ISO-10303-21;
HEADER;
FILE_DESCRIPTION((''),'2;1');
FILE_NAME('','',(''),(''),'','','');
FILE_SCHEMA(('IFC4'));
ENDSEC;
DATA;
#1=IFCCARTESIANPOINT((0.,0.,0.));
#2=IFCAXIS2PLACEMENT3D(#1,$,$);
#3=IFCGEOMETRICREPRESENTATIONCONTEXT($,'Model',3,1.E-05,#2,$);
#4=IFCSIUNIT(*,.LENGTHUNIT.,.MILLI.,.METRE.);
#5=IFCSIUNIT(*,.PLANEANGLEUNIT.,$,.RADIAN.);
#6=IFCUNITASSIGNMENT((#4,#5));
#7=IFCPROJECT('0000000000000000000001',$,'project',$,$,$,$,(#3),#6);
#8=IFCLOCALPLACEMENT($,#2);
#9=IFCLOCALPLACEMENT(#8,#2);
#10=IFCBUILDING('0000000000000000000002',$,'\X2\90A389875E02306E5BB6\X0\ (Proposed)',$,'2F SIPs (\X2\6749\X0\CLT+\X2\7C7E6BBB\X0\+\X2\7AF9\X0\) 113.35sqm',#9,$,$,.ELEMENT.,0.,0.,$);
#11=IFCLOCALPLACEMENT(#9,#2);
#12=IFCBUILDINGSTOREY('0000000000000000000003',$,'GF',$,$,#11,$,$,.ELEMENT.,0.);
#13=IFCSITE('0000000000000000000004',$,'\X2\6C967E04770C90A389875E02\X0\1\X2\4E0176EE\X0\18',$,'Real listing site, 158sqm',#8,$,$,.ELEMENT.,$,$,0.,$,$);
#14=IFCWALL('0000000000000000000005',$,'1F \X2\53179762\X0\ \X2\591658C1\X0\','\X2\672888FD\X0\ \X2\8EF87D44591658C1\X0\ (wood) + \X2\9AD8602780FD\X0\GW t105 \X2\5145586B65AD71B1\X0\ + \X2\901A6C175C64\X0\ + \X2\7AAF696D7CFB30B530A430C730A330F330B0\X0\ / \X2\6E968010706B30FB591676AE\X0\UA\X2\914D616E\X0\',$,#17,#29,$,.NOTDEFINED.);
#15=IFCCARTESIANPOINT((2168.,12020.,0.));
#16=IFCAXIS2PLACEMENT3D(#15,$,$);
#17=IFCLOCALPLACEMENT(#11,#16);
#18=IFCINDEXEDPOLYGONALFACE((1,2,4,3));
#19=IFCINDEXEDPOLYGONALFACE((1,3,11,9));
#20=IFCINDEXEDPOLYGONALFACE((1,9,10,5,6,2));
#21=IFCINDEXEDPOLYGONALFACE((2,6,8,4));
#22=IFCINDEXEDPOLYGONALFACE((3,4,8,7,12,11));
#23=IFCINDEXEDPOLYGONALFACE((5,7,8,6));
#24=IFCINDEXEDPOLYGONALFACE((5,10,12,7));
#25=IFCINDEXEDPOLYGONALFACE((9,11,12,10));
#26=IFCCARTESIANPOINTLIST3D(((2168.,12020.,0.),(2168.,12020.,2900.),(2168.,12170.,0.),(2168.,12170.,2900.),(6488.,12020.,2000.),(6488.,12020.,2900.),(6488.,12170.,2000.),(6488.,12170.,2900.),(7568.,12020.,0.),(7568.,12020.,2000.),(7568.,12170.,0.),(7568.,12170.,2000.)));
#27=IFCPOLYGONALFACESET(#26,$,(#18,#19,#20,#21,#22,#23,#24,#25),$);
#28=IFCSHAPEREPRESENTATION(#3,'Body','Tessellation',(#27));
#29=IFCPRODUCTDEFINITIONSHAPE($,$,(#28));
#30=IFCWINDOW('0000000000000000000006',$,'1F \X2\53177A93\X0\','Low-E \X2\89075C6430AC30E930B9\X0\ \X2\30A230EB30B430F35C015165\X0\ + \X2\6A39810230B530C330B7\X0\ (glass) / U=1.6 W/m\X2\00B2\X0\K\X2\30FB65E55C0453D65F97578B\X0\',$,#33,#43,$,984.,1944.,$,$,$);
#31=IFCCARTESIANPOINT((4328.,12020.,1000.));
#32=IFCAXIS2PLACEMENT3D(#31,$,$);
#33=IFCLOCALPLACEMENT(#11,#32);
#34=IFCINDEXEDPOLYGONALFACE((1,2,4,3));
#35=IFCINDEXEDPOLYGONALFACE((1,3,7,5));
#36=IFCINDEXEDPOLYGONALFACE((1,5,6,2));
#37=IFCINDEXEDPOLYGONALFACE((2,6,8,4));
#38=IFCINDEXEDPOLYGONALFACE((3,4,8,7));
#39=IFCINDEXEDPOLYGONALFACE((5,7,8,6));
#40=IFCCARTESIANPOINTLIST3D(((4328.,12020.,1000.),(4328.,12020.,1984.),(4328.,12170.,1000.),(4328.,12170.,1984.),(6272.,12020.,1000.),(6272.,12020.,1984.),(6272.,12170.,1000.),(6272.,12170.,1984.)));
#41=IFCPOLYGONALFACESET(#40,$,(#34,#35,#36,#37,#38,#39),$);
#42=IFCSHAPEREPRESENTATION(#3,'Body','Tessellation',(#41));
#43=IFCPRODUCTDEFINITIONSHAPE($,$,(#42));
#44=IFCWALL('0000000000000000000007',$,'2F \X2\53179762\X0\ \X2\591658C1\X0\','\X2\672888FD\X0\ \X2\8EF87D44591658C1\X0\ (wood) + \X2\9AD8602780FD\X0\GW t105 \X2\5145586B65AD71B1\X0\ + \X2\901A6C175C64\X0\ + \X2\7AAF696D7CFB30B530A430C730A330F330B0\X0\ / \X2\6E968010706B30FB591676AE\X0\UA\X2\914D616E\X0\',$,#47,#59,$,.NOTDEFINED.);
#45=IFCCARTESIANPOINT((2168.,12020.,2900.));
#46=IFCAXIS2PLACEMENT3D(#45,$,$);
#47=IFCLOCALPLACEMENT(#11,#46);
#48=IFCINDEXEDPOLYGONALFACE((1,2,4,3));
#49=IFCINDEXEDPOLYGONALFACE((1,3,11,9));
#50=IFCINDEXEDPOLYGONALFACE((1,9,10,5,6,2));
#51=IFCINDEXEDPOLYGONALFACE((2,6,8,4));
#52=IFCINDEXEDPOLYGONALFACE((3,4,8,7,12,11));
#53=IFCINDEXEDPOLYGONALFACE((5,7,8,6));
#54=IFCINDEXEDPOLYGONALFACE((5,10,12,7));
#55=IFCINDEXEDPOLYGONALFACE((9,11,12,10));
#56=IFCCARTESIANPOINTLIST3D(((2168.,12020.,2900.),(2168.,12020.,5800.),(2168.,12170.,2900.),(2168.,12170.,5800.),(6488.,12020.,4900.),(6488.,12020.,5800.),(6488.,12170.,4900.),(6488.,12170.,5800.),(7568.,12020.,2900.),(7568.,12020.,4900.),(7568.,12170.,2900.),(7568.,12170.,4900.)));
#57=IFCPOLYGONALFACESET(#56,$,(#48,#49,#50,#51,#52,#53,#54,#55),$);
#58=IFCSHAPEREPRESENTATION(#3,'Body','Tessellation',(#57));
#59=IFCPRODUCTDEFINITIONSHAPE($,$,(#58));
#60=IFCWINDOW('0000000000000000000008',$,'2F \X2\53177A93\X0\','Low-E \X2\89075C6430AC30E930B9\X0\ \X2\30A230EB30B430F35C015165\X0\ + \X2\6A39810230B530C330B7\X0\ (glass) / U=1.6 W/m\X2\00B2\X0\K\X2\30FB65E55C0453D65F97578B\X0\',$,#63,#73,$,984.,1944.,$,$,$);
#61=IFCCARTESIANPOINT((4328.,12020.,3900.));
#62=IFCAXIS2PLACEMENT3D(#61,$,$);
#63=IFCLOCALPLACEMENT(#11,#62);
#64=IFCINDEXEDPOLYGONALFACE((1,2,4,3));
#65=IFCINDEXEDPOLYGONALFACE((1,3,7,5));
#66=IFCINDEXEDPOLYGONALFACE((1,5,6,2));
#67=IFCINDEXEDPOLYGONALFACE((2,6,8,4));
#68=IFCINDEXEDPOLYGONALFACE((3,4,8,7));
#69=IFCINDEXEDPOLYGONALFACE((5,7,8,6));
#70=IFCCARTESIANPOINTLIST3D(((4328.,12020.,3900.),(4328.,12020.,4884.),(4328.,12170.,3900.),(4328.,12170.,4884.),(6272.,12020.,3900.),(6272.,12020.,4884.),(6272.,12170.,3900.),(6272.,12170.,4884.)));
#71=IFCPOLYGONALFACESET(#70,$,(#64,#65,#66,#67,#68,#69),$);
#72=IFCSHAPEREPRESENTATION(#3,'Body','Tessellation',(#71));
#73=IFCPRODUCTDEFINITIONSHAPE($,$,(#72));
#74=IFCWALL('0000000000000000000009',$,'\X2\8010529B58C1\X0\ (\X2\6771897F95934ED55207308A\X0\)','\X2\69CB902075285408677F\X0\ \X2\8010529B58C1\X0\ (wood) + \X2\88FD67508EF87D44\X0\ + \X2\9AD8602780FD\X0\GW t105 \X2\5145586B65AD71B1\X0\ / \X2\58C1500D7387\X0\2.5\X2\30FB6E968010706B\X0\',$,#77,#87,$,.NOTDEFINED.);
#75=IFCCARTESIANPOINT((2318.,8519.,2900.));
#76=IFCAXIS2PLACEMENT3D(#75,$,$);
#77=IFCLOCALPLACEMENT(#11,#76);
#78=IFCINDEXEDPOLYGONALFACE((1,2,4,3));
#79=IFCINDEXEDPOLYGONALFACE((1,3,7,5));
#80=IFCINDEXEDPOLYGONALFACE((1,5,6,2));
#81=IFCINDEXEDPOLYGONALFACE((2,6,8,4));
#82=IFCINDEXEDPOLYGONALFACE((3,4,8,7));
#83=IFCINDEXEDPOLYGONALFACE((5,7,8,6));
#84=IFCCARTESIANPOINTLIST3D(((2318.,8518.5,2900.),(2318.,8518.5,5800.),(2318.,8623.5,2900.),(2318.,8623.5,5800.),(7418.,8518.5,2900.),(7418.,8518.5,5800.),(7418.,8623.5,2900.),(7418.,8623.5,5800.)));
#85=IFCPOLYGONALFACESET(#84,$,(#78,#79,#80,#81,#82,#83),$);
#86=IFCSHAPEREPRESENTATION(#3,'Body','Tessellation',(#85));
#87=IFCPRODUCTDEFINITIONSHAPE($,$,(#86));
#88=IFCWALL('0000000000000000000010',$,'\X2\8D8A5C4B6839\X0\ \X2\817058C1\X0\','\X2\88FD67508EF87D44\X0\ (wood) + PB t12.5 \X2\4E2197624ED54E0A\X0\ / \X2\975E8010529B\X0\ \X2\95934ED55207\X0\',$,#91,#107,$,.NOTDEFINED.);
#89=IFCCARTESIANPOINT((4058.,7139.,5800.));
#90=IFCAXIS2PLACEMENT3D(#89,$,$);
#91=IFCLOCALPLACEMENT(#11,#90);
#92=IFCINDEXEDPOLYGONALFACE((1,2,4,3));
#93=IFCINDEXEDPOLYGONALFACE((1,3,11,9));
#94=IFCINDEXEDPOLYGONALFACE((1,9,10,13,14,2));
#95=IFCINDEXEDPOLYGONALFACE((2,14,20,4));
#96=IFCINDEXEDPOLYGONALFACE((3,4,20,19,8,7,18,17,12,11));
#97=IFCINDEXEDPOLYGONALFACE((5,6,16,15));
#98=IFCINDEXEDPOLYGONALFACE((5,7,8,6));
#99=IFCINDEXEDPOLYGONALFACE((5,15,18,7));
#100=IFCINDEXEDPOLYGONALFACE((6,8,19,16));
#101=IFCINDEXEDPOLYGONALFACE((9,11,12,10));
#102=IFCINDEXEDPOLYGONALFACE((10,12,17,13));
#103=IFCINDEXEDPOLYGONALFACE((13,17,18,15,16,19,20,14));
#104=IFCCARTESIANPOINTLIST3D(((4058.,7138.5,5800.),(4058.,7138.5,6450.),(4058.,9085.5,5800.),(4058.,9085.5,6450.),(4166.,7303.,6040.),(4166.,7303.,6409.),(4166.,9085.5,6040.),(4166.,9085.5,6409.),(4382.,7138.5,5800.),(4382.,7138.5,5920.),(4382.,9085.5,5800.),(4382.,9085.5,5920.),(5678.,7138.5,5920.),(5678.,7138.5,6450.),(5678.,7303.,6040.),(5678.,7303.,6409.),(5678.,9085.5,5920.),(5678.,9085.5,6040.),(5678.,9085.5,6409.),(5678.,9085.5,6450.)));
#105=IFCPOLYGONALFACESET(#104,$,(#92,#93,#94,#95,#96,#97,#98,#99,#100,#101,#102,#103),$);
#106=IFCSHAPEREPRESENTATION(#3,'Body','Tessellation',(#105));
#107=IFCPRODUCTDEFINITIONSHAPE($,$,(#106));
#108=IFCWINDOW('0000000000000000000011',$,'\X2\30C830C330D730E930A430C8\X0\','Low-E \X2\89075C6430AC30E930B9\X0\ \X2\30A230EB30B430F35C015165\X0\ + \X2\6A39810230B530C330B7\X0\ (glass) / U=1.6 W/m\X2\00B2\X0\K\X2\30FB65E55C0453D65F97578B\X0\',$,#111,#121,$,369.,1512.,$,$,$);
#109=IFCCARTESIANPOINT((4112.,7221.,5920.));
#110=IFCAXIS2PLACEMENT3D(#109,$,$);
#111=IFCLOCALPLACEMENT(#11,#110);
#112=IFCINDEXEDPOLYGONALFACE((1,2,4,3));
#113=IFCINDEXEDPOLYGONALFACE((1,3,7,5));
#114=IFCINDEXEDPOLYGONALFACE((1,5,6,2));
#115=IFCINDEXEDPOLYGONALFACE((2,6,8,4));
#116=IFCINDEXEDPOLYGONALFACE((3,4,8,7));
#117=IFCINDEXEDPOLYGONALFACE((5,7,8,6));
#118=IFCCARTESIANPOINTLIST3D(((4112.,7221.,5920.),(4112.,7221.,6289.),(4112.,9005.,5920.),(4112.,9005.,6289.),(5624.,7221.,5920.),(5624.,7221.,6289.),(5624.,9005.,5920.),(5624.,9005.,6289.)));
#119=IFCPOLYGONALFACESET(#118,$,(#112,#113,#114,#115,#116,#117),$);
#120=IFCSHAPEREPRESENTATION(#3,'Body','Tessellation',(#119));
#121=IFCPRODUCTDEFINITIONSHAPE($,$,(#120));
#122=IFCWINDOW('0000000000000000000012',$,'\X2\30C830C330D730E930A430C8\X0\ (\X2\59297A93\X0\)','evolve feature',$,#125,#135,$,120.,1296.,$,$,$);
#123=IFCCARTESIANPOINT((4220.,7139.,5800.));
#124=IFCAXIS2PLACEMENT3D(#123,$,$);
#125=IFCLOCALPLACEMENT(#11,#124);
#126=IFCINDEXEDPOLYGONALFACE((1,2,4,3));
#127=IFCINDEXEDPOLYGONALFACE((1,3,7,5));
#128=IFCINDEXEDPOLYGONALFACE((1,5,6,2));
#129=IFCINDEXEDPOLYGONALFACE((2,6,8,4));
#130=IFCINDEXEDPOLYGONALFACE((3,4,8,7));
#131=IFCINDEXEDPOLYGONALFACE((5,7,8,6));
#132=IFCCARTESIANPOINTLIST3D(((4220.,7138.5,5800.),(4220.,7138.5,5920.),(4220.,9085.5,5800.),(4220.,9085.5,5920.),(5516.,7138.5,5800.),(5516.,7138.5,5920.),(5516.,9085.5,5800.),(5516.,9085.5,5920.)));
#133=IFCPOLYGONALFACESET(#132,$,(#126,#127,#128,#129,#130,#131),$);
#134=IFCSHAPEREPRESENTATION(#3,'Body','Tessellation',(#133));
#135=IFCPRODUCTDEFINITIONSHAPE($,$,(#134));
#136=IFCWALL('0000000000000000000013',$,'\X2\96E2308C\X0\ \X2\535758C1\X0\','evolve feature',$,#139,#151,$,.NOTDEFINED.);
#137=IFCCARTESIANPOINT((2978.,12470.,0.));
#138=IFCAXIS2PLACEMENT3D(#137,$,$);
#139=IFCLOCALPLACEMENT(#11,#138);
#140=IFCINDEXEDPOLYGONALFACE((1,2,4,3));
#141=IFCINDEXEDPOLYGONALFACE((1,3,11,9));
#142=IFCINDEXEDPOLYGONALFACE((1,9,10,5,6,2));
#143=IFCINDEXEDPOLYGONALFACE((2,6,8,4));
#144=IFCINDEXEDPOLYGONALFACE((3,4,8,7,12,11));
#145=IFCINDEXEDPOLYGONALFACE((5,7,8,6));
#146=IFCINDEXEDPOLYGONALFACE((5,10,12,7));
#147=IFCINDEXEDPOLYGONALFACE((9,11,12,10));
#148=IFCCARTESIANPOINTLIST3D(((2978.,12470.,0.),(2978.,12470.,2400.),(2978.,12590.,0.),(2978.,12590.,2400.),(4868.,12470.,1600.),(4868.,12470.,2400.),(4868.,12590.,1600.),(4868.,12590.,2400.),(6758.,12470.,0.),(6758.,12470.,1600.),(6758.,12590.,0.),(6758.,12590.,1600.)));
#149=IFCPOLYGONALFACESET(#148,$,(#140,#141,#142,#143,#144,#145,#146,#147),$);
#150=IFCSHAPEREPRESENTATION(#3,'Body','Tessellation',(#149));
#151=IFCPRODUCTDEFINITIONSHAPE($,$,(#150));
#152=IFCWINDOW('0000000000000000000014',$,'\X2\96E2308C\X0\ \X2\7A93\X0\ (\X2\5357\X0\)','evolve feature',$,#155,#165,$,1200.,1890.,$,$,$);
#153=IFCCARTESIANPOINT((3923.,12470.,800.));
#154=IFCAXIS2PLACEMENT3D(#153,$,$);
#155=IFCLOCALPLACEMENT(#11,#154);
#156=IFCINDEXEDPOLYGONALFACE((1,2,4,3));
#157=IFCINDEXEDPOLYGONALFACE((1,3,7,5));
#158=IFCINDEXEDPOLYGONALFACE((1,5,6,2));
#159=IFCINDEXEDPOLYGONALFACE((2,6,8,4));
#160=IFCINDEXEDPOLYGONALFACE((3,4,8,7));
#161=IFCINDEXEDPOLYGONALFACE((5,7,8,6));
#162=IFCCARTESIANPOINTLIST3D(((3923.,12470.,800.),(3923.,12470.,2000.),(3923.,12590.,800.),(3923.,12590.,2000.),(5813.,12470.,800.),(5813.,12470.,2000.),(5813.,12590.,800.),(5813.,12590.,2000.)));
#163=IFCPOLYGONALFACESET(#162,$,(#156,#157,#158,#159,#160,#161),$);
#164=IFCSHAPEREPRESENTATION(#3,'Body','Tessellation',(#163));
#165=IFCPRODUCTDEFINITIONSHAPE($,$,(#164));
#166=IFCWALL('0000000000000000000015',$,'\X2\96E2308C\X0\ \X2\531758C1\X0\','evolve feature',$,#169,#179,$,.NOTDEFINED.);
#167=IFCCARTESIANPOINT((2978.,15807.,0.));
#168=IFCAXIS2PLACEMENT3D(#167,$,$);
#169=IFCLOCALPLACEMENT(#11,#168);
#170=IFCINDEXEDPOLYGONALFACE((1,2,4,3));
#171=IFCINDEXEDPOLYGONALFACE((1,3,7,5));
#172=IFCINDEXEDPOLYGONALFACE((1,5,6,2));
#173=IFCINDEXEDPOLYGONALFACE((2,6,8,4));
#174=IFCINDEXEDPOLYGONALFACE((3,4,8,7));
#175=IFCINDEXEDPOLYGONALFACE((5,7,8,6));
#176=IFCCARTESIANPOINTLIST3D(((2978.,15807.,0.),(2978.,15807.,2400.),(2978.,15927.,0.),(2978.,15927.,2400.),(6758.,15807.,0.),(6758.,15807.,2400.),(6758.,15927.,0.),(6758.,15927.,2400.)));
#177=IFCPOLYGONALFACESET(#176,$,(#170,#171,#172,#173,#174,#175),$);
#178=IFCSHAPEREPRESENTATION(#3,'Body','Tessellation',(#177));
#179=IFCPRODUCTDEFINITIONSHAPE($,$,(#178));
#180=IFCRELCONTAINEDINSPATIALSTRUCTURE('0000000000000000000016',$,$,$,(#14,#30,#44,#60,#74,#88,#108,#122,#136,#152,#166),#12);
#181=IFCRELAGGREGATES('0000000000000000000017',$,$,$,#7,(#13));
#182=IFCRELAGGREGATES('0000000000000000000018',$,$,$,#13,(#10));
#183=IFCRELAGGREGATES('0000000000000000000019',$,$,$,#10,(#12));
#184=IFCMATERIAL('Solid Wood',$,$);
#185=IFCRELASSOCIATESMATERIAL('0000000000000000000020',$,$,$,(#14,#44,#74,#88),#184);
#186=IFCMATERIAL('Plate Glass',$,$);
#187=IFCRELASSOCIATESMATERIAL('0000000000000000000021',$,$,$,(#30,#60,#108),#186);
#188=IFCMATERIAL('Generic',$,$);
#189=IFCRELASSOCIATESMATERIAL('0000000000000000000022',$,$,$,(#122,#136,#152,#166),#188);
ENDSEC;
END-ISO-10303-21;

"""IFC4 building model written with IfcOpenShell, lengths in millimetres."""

from ifc_helpers import new_model, si_unit, frame, frame_2d, origin, place, context, project, spatial, rectangle, extrude, material, element, fill, save


model = new_model("IFC4")

# Units and contexts
model_context = context("Model", 3, precision=1e-05, world=origin())
ifc_project = project(units=[si_unit("LENGTHUNIT", "METRE", prefix="MILLI"), si_unit("PLANEANGLEUNIT", "RADIAN")], contexts=[model_context])

# Site, building, storey
site_placement = place(None, origin())
site = spatial("IfcSite", under=ifc_project, at=site_placement, Name="沖縄県那覇市1丁目18", ObjectType="Real listing site, 158sqm", CompositionType="ELEMENT", RefElevation=0.0)
building_placement = place(site_placement, origin())
building = spatial("IfcBuilding", under=site, at=building_placement, Name="那覇市の家 (Proposed)", ObjectType="2F SIPs (杉CLT+籾殻+竹) 113.35sqm", CompositionType="ELEMENT", ElevationOfRefHeight=0.0, ElevationOfTerrain=0.0)
storey_placement = place(building_placement, origin())
storey = spatial("IfcBuildingStorey", under=building, at=storey_placement, Name="GF", CompositionType="ELEMENT", Elevation=0.0)

# Shared definitions
ifc_material_1 = material(Name="Generic")

# Wall, opening, window
ifc_material_2 = material(Name="Solid Wood")
wall_1_placement = place(storey_placement, frame((2168.0, 12020.0, 0.0)))
wall_1 = element("IfcWall", 1, at=wall_1_placement, inside=storey, material=ifc_material_2, Name="1F 北面 外壁", Description="木製 軸組外壁 (wood) + 高性能GW t105 充填断熱 + 通気層 + 窯業系サイディング / 準耐火・外皮UA配慮", PredefinedType="NOTDEFINED", context=model_context, shape_type="SweptSolid", body=[
    extrude(rectangle(XDim=5400.0, YDim=150.0, at=frame_2d((2700.0, 75.0))), frame((2168.0, 12020.0, 0.0)), (0.0, 0.0, 1.0), 2900.0),
])
opening_1_placement = place(storey_placement, frame((4328.0, 12020.0, 1000.0)))
opening_1 = element("IfcOpeningElement", 2, at=opening_1_placement, cuts=wall_1, PredefinedType="NOTDEFINED", context=model_context, shape_type="SweptSolid", body=[
    extrude(rectangle(XDim=1944.0, YDim=150.0, at=frame_2d((972.0, 75.0))), frame((4328.0, 12020.0, 1000.0)), (0.0, 0.0, 1.0), 984.0),
])
ifc_material_3 = material(Name="Plate Glass")
window_1_placement = place(storey_placement, frame((4328.0, 12020.0, 1000.0)))
window_1 = element("IfcWindow", 3, at=window_1_placement, inside=storey, material=ifc_material_3, Name="1F 北窓", Description="Low-E 複層ガラス アルゴン封入 + 樹脂サッシ (glass) / U=1.6 W/m²K・日射取得型", OverallHeight=984.0, OverallWidth=1944.0, context=model_context, shape_type="SweptSolid", body=[
    extrude(rectangle(XDim=1944.0, YDim=150.0, at=frame_2d((972.0, 75.0))), frame((4328.0, 12020.0, 1000.0)), (0.0, 0.0, 1.0), 984.0),
])
fill(opening_1, window_1)

# Wall, opening, window
wall_2_placement = place(storey_placement, frame((2168.0, 12020.0, 2900.0)))
wall_2 = element("IfcWall", 4, at=wall_2_placement, inside=storey, material=ifc_material_2, Name="2F 北面 外壁", Description="木製 軸組外壁 (wood) + 高性能GW t105 充填断熱 + 通気層 + 窯業系サイディング / 準耐火・外皮UA配慮", PredefinedType="NOTDEFINED", context=model_context, shape_type="SweptSolid", body=[
    extrude(rectangle(XDim=5400.0, YDim=150.0, at=frame_2d((2700.0, 75.0))), frame((2168.0, 12020.0, 2900.0)), (0.0, 0.0, 1.0), 2900.0),
])
opening_2_placement = place(storey_placement, frame((4328.0, 12020.0, 3900.0)))
opening_2 = element("IfcOpeningElement", 5, at=opening_2_placement, cuts=wall_2, PredefinedType="NOTDEFINED", context=model_context, shape_type="SweptSolid", body=[
    extrude(rectangle(XDim=1944.0, YDim=150.0, at=frame_2d((972.0, 75.0))), frame((4328.0, 12020.0, 3900.0)), (0.0, 0.0, 1.0), 984.0),
])
window_2_placement = place(storey_placement, frame((4328.0, 12020.0, 3900.0)))
window_2 = element("IfcWindow", 6, at=window_2_placement, inside=storey, material=ifc_material_3, Name="2F 北窓", Description="Low-E 複層ガラス アルゴン封入 + 樹脂サッシ (glass) / U=1.6 W/m²K・日射取得型", OverallHeight=984.0, OverallWidth=1944.0, context=model_context, shape_type="SweptSolid", body=[
    extrude(rectangle(XDim=1944.0, YDim=150.0, at=frame_2d((972.0, 75.0))), frame((4328.0, 12020.0, 3900.0)), (0.0, 0.0, 1.0), 984.0),
])
fill(opening_2, window_2)

# Wall
wall_3_placement = place(storey_placement, frame((2318.0, 8519.0, 2900.0)))
element("IfcWall", 7, at=wall_3_placement, inside=storey, material=ifc_material_2, Name="耐力壁 (東西間仕切り)", Description="構造用合板 耐力壁 (wood) + 製材軸組 + 高性能GW t105 充填断熱 / 壁倍率2.5・準耐火", PredefinedType="NOTDEFINED", context=model_context, shape_type="SweptSolid", body=[
    extrude(rectangle(XDim=5100.0, YDim=105.0, at=frame_2d((2550.0, 52.0))), frame((2318.0, 8519.0, 2900.0)), (0.0, 0.0, 1.0), 2900.0),
])

# Wall, openings, windows
wall_4_placement = place(storey_placement, frame((4058.0, 7139.0, 5800.0)))
wall_4 = element("IfcWall", 8, at=wall_4_placement, inside=storey, material=ifc_material_2, Name="越屋根 腰壁", Description="製材軸組 (wood) + PB t12.5 両面仕上 / 非耐力 間仕切", PredefinedType="NOTDEFINED", context=model_context, shape_type="SweptSolid", body=[
    extrude(rectangle(XDim=1620.0, YDim=1947.0, at=frame_2d((810.0, 973.0))), frame((4058.0, 7139.0, 5800.0)), (0.0, 0.0, 1.0), 650.0),
])
opening_3_placement = place(storey_placement, frame((4112.0, 7221.0, 5920.0)))
opening_3 = element("IfcOpeningElement", 9, at=opening_3_placement, cuts=wall_4, PredefinedType="NOTDEFINED", context=model_context, shape_type="SweptSolid", body=[
    extrude(rectangle(XDim=1512.0, YDim=1784.0, at=frame_2d((756.0, 892.0))), frame((4112.0, 7221.0, 5920.0)), (0.0, 0.0, 1.0), 369.0),
])
opening_4_placement = place(storey_placement, frame((4220.0, 7139.0, 5800.0)))
opening_4 = element("IfcOpeningElement", 10, at=opening_4_placement, cuts=wall_4, PredefinedType="NOTDEFINED", context=model_context, shape_type="SweptSolid", body=[
    extrude(rectangle(XDim=1296.0, YDim=1947.0, at=frame_2d((648.0, 973.0))), frame((4220.0, 7139.0, 5800.0)), (0.0, 0.0, 1.0), 120.0),
])
window_3_placement = place(storey_placement, frame((4112.0, 7221.0, 5920.0)))
window_3 = element("IfcWindow", 11, at=window_3_placement, inside=storey, material=ifc_material_3, Name="トップライト", Description="Low-E 複層ガラス アルゴン封入 + 樹脂サッシ (glass) / U=1.6 W/m²K・日射取得型", OverallHeight=369.0, OverallWidth=1512.0, context=model_context, shape_type="SweptSolid", body=[
    extrude(rectangle(XDim=1512.0, YDim=1784.0, at=frame_2d((756.0, 892.0))), frame((4112.0, 7221.0, 5920.0)), (0.0, 0.0, 1.0), 369.0),
])
fill(opening_3, window_3)
window_4_placement = place(storey_placement, frame((4220.0, 7139.0, 5800.0)))
window_4 = element("IfcWindow", 12, at=window_4_placement, inside=storey, material=ifc_material_1, Name="トップライト (天窓)", Description="evolve feature", OverallHeight=120.0, OverallWidth=1296.0, context=model_context, shape_type="SweptSolid", body=[
    extrude(rectangle(XDim=1296.0, YDim=1947.0, at=frame_2d((648.0, 973.0))), frame((4220.0, 7139.0, 5800.0)), (0.0, 0.0, 1.0), 120.0),
])
fill(opening_4, window_4)

# Wall, opening, window
wall_5_placement = place(storey_placement, frame((2978.0, 12470.0, 0.0)))
wall_5 = element("IfcWall", 13, at=wall_5_placement, inside=storey, material=ifc_material_1, Name="離れ 南壁", Description="evolve feature", PredefinedType="NOTDEFINED", context=model_context, shape_type="SweptSolid", body=[
    extrude(rectangle(XDim=3780.0, YDim=120.0, at=frame_2d((1890.0, 60.0))), frame((2978.0, 12470.0, 0.0)), (0.0, 0.0, 1.0), 2400.0),
])
opening_5_placement = place(storey_placement, frame((3923.0, 12470.0, 800.0)))
opening_5 = element("IfcOpeningElement", 14, at=opening_5_placement, cuts=wall_5, PredefinedType="NOTDEFINED", context=model_context, shape_type="SweptSolid", body=[
    extrude(rectangle(XDim=1890.0, YDim=120.0, at=frame_2d((945.0, 60.0))), frame((3923.0, 12470.0, 800.0)), (0.0, 0.0, 1.0), 1200.0),
])
window_5_placement = place(storey_placement, frame((3923.0, 12470.0, 800.0)))
window_5 = element("IfcWindow", 15, at=window_5_placement, inside=storey, material=ifc_material_1, Name="離れ 窓 (南)", Description="evolve feature", OverallHeight=1200.0, OverallWidth=1890.0, context=model_context, shape_type="SweptSolid", body=[
    extrude(rectangle(XDim=1890.0, YDim=120.0, at=frame_2d((945.0, 60.0))), frame((3923.0, 12470.0, 800.0)), (0.0, 0.0, 1.0), 1200.0),
])
fill(opening_5, window_5)

# Wall
wall_6_placement = place(storey_placement, frame((2978.0, 15807.0, 0.0)))
element("IfcWall", 16, at=wall_6_placement, inside=storey, material=ifc_material_1, Name="離れ 北壁", Description="evolve feature", PredefinedType="NOTDEFINED", context=model_context, shape_type="SweptSolid", body=[
    extrude(rectangle(XDim=3780.0, YDim=120.0, at=frame_2d((1890.0, 60.0))), frame((2978.0, 15807.0, 0.0)), (0.0, 0.0, 1.0), 2400.0),
])

save(model, "model.ifc")
